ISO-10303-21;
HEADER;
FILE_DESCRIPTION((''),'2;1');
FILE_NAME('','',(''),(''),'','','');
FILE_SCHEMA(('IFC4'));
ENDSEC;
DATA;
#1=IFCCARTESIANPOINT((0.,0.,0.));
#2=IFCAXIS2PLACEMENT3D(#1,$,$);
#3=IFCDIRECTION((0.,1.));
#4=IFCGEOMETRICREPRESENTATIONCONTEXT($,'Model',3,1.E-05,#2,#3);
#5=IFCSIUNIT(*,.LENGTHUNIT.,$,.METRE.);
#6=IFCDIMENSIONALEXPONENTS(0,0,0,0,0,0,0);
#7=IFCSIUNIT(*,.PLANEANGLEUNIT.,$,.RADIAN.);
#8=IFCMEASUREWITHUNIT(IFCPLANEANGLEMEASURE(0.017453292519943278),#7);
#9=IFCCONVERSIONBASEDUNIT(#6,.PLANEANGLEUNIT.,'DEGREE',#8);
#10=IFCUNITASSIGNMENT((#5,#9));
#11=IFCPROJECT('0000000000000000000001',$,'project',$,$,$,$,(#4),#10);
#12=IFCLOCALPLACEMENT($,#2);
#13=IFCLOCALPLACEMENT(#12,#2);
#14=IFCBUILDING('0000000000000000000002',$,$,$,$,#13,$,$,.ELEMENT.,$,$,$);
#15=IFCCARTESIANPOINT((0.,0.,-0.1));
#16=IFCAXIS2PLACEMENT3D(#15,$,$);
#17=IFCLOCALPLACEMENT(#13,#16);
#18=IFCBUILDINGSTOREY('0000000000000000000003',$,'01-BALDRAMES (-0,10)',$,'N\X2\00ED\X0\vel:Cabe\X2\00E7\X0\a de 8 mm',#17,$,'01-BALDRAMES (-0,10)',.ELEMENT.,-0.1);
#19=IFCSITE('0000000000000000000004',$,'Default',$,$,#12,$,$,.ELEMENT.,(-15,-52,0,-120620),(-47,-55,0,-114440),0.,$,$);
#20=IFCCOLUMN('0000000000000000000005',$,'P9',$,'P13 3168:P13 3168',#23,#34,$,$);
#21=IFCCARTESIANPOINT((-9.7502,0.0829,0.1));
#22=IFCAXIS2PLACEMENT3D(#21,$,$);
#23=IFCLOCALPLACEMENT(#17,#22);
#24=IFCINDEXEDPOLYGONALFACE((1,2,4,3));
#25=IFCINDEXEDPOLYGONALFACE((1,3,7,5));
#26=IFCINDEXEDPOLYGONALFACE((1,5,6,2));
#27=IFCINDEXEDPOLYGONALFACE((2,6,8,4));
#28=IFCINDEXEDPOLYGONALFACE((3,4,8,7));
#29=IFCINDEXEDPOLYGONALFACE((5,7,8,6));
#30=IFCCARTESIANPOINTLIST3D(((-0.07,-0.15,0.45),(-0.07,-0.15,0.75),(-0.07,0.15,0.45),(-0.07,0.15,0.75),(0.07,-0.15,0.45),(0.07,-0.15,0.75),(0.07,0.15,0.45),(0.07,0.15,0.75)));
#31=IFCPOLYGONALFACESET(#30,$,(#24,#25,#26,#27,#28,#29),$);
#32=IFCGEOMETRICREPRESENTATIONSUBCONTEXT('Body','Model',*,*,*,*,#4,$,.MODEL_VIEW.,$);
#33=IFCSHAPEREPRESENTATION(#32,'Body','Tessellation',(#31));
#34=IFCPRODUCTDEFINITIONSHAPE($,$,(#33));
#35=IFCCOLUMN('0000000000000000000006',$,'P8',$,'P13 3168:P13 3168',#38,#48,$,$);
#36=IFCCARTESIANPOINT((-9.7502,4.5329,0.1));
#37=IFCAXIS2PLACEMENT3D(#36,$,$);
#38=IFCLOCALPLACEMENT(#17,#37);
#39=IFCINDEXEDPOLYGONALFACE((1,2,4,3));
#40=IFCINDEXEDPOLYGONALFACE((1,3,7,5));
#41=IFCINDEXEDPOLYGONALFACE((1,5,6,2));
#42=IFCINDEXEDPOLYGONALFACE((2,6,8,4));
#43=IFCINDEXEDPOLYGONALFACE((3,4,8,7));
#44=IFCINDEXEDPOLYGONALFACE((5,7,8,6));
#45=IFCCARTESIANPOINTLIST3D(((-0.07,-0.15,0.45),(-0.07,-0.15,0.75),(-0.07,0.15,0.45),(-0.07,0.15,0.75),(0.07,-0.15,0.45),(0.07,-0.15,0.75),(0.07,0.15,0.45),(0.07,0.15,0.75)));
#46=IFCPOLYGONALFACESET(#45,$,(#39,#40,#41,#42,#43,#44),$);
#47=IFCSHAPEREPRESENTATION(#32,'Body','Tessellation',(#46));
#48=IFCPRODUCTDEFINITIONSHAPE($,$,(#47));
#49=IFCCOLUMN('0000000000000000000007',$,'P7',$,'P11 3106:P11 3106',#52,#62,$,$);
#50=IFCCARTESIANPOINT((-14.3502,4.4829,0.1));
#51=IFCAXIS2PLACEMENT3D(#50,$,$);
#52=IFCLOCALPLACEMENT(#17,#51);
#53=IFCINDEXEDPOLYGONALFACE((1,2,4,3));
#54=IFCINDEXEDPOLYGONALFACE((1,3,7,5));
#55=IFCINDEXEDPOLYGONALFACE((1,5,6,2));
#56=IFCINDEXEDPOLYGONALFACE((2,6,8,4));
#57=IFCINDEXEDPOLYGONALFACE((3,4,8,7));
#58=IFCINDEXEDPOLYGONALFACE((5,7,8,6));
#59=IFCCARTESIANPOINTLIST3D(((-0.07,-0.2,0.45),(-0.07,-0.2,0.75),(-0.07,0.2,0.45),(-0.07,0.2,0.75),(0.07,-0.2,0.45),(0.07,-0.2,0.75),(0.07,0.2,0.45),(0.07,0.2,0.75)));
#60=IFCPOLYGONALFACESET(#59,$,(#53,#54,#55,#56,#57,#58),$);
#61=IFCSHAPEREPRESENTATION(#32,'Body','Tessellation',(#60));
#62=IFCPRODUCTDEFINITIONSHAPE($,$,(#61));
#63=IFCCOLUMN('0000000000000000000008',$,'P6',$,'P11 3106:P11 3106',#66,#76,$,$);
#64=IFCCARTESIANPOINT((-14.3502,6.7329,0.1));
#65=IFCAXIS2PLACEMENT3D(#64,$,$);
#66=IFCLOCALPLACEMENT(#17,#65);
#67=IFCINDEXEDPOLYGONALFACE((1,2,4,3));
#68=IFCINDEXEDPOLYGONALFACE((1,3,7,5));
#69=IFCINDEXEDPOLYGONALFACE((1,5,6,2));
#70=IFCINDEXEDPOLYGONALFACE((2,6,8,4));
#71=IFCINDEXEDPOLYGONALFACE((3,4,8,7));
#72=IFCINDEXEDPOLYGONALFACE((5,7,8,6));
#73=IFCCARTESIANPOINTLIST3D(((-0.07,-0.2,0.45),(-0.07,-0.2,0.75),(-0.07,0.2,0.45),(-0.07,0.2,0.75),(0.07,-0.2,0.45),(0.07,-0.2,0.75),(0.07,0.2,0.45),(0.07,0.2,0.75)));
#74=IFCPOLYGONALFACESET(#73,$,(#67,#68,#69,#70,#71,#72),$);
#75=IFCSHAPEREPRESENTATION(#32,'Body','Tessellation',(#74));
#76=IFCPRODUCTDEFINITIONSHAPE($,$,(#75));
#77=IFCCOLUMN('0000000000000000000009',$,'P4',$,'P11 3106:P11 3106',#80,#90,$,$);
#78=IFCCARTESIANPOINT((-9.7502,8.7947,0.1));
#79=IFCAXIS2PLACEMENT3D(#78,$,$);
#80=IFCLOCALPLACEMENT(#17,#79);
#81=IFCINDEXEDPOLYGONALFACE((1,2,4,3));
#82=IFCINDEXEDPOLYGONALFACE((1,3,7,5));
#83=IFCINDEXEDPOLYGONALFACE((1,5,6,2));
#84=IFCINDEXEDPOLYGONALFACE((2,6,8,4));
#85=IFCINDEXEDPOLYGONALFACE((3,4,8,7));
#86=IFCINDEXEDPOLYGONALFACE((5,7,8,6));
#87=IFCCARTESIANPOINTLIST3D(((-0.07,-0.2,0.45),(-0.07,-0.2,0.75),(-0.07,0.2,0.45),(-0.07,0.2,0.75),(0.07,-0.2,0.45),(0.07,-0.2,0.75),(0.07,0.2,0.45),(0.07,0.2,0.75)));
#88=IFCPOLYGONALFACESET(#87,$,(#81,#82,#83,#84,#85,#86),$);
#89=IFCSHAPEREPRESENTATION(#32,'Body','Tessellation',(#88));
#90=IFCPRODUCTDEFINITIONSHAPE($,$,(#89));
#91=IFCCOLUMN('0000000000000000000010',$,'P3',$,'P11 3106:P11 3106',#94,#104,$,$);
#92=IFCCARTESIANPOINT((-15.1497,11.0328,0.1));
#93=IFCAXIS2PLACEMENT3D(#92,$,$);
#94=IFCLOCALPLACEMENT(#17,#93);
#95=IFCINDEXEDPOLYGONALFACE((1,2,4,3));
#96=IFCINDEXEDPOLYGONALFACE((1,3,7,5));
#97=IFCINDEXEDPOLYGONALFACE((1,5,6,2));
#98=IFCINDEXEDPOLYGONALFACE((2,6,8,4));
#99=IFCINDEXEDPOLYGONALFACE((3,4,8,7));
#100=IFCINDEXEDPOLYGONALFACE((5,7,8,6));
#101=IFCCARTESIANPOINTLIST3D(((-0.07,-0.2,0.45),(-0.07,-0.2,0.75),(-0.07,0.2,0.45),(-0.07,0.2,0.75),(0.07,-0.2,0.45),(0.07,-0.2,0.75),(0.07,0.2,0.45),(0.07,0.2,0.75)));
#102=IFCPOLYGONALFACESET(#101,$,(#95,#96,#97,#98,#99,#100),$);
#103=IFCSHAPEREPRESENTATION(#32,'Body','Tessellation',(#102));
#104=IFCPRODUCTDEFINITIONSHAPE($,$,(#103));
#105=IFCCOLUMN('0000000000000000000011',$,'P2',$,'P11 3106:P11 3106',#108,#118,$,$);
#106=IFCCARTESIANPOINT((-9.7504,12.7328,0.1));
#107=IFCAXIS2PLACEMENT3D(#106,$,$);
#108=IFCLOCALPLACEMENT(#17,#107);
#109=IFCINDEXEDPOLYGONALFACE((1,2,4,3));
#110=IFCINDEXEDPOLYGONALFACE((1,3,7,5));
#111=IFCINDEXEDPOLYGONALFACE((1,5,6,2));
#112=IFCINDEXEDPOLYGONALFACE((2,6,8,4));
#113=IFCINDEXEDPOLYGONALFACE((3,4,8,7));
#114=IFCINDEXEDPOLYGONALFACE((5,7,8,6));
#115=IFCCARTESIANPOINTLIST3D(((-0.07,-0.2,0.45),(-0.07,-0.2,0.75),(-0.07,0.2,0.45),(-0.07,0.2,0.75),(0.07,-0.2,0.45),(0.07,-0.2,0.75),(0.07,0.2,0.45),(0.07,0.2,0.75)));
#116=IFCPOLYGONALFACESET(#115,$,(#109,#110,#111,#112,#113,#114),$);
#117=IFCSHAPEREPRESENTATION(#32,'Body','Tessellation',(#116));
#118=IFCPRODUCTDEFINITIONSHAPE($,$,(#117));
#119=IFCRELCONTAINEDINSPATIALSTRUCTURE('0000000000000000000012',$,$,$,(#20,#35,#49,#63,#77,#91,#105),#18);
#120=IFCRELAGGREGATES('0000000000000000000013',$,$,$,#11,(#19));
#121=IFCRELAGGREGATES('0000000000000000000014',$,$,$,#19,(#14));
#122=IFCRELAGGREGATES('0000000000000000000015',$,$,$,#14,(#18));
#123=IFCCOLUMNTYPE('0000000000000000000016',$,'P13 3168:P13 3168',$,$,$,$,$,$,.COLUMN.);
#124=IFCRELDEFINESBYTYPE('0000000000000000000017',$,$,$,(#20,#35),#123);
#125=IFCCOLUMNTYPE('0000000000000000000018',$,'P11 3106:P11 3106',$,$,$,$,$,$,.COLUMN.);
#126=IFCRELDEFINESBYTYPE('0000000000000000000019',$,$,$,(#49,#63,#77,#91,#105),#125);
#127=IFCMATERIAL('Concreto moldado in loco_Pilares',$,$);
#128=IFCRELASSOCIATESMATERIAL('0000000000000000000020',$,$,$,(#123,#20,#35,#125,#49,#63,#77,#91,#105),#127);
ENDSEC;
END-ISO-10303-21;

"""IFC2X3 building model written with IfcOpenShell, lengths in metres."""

from ifc_helpers import new_model, entity, si_unit, converted_unit, direction, frame, origin, origin_2d_with_axis, place, context, subcontext, project, spatial, rectangle, extrude, source, transform, mapped, material, type_object, type_shapes, element, save


model = new_model("IFC2X3")

# Units and contexts
model_context = context("Model", 3, precision=1e-05, world=origin(), true_north=direction((0.0, 1.0)))
body_context = subcontext(model_context, "Body", "Model", "MODEL_VIEW")
ifc_project = project(units=[si_unit("LENGTHUNIT", "METRE"), converted_unit("PLANEANGLEUNIT", "DEGREE", entity("IfcPlaneAngleMeasure", 0.017453292519943278), si_unit("PLANEANGLEUNIT", "RADIAN"), dimensions=[0, 0, 0, 0, 0, 0, 0])], contexts=[model_context])

# Site, building, storey
site_placement = place(None, origin())
site = spatial("IfcSite", under=ifc_project, at=site_placement, Name="Default", CompositionType="ELEMENT", RefLatitude=(-15, -52, 0, -120620), RefLongitude=(-47, -55, 0, -114440), RefElevation=0.0)
building_placement = place(site_placement, origin())
building = spatial("IfcBuilding", under=site, at=building_placement, CompositionType="ELEMENT")
storey_placement = place(building_placement, frame((0.0, 0.0, -0.1)))
storey = spatial("IfcBuildingStorey", under=building, at=storey_placement, Name="01-BALDRAMES (-0,10)", ObjectType="Nível:Cabeça de 8 mm", LongName="01-BALDRAMES (-0,10)", CompositionType="ELEMENT", Elevation=-0.1)

# Columns
ifc_material_1 = material(Name="Concreto moldado in loco_Pilares")
column_type_1 = type_object("IfcColumnType", Name="P13 3168:P13 3168", PredefinedType="COLUMN", material=ifc_material_1)
shared_shape_1 = source(origin(), body_context, "Body", "SweptSolid", [
    extrude(rectangle(XDim=0.3, YDim=0.14, at=origin_2d_with_axis()), frame((0.0, 0.0, 0.45), z_axis=(0.0, 0.0, 1.0), x_axis=(0.0, -1.0, 0.0)), (0.0, 0.0, 1.0), 0.3),
])
type_shapes(column_type_1, [shared_shape_1])
for number, where, name in (
    (1, (-9.7502, 0.0829, 0.1), "P9"),
    (2, (-9.7502, 4.5329, 0.1), "P8"),
):
    element("IfcColumn", number, at=place(storey_placement, frame(where)), inside=storey, type_object=column_type_1, material=ifc_material_1, Name=name, ObjectType="P13 3168:P13 3168", context=body_context, shape_type="MappedRepresentation", body=[
        mapped(shared_shape_1, transform((0.0, 0.0, 0.0), scale=1.0)),
    ])
column_type_2 = type_object("IfcColumnType", Name="P11 3106:P11 3106", PredefinedType="COLUMN", material=ifc_material_1)
shared_shape_2 = source(origin(), body_context, "Body", "SweptSolid", [
    extrude(rectangle(XDim=0.4, YDim=0.14, at=origin_2d_with_axis()), frame((0.0, 0.0, 0.45), z_axis=(0.0, 0.0, 1.0), x_axis=(0.0, -1.0, 0.0)), (0.0, 0.0, 1.0), 0.3),
])
type_shapes(column_type_2, [shared_shape_2])
for number, where, name in (
    (3, (-14.3502, 4.4829, 0.1), "P7"),
    (4, (-14.3502, 6.7329, 0.1), "P6"),
    (5, (-9.7502, 8.7947, 0.1), "P4"),
    (6, (-15.1497, 11.0328, 0.1), "P3"),
    (7, (-9.7504, 12.7328, 0.1), "P2"),
):
    element("IfcColumn", number, at=place(storey_placement, frame(where)), inside=storey, type_object=column_type_2, material=ifc_material_1, Name=name, ObjectType="P11 3106:P11 3106", context=body_context, shape_type="MappedRepresentation", body=[
        mapped(shared_shape_2, transform((0.0, 0.0, 0.0), scale=1.0)),
    ])

save(model, "model.ifc")
